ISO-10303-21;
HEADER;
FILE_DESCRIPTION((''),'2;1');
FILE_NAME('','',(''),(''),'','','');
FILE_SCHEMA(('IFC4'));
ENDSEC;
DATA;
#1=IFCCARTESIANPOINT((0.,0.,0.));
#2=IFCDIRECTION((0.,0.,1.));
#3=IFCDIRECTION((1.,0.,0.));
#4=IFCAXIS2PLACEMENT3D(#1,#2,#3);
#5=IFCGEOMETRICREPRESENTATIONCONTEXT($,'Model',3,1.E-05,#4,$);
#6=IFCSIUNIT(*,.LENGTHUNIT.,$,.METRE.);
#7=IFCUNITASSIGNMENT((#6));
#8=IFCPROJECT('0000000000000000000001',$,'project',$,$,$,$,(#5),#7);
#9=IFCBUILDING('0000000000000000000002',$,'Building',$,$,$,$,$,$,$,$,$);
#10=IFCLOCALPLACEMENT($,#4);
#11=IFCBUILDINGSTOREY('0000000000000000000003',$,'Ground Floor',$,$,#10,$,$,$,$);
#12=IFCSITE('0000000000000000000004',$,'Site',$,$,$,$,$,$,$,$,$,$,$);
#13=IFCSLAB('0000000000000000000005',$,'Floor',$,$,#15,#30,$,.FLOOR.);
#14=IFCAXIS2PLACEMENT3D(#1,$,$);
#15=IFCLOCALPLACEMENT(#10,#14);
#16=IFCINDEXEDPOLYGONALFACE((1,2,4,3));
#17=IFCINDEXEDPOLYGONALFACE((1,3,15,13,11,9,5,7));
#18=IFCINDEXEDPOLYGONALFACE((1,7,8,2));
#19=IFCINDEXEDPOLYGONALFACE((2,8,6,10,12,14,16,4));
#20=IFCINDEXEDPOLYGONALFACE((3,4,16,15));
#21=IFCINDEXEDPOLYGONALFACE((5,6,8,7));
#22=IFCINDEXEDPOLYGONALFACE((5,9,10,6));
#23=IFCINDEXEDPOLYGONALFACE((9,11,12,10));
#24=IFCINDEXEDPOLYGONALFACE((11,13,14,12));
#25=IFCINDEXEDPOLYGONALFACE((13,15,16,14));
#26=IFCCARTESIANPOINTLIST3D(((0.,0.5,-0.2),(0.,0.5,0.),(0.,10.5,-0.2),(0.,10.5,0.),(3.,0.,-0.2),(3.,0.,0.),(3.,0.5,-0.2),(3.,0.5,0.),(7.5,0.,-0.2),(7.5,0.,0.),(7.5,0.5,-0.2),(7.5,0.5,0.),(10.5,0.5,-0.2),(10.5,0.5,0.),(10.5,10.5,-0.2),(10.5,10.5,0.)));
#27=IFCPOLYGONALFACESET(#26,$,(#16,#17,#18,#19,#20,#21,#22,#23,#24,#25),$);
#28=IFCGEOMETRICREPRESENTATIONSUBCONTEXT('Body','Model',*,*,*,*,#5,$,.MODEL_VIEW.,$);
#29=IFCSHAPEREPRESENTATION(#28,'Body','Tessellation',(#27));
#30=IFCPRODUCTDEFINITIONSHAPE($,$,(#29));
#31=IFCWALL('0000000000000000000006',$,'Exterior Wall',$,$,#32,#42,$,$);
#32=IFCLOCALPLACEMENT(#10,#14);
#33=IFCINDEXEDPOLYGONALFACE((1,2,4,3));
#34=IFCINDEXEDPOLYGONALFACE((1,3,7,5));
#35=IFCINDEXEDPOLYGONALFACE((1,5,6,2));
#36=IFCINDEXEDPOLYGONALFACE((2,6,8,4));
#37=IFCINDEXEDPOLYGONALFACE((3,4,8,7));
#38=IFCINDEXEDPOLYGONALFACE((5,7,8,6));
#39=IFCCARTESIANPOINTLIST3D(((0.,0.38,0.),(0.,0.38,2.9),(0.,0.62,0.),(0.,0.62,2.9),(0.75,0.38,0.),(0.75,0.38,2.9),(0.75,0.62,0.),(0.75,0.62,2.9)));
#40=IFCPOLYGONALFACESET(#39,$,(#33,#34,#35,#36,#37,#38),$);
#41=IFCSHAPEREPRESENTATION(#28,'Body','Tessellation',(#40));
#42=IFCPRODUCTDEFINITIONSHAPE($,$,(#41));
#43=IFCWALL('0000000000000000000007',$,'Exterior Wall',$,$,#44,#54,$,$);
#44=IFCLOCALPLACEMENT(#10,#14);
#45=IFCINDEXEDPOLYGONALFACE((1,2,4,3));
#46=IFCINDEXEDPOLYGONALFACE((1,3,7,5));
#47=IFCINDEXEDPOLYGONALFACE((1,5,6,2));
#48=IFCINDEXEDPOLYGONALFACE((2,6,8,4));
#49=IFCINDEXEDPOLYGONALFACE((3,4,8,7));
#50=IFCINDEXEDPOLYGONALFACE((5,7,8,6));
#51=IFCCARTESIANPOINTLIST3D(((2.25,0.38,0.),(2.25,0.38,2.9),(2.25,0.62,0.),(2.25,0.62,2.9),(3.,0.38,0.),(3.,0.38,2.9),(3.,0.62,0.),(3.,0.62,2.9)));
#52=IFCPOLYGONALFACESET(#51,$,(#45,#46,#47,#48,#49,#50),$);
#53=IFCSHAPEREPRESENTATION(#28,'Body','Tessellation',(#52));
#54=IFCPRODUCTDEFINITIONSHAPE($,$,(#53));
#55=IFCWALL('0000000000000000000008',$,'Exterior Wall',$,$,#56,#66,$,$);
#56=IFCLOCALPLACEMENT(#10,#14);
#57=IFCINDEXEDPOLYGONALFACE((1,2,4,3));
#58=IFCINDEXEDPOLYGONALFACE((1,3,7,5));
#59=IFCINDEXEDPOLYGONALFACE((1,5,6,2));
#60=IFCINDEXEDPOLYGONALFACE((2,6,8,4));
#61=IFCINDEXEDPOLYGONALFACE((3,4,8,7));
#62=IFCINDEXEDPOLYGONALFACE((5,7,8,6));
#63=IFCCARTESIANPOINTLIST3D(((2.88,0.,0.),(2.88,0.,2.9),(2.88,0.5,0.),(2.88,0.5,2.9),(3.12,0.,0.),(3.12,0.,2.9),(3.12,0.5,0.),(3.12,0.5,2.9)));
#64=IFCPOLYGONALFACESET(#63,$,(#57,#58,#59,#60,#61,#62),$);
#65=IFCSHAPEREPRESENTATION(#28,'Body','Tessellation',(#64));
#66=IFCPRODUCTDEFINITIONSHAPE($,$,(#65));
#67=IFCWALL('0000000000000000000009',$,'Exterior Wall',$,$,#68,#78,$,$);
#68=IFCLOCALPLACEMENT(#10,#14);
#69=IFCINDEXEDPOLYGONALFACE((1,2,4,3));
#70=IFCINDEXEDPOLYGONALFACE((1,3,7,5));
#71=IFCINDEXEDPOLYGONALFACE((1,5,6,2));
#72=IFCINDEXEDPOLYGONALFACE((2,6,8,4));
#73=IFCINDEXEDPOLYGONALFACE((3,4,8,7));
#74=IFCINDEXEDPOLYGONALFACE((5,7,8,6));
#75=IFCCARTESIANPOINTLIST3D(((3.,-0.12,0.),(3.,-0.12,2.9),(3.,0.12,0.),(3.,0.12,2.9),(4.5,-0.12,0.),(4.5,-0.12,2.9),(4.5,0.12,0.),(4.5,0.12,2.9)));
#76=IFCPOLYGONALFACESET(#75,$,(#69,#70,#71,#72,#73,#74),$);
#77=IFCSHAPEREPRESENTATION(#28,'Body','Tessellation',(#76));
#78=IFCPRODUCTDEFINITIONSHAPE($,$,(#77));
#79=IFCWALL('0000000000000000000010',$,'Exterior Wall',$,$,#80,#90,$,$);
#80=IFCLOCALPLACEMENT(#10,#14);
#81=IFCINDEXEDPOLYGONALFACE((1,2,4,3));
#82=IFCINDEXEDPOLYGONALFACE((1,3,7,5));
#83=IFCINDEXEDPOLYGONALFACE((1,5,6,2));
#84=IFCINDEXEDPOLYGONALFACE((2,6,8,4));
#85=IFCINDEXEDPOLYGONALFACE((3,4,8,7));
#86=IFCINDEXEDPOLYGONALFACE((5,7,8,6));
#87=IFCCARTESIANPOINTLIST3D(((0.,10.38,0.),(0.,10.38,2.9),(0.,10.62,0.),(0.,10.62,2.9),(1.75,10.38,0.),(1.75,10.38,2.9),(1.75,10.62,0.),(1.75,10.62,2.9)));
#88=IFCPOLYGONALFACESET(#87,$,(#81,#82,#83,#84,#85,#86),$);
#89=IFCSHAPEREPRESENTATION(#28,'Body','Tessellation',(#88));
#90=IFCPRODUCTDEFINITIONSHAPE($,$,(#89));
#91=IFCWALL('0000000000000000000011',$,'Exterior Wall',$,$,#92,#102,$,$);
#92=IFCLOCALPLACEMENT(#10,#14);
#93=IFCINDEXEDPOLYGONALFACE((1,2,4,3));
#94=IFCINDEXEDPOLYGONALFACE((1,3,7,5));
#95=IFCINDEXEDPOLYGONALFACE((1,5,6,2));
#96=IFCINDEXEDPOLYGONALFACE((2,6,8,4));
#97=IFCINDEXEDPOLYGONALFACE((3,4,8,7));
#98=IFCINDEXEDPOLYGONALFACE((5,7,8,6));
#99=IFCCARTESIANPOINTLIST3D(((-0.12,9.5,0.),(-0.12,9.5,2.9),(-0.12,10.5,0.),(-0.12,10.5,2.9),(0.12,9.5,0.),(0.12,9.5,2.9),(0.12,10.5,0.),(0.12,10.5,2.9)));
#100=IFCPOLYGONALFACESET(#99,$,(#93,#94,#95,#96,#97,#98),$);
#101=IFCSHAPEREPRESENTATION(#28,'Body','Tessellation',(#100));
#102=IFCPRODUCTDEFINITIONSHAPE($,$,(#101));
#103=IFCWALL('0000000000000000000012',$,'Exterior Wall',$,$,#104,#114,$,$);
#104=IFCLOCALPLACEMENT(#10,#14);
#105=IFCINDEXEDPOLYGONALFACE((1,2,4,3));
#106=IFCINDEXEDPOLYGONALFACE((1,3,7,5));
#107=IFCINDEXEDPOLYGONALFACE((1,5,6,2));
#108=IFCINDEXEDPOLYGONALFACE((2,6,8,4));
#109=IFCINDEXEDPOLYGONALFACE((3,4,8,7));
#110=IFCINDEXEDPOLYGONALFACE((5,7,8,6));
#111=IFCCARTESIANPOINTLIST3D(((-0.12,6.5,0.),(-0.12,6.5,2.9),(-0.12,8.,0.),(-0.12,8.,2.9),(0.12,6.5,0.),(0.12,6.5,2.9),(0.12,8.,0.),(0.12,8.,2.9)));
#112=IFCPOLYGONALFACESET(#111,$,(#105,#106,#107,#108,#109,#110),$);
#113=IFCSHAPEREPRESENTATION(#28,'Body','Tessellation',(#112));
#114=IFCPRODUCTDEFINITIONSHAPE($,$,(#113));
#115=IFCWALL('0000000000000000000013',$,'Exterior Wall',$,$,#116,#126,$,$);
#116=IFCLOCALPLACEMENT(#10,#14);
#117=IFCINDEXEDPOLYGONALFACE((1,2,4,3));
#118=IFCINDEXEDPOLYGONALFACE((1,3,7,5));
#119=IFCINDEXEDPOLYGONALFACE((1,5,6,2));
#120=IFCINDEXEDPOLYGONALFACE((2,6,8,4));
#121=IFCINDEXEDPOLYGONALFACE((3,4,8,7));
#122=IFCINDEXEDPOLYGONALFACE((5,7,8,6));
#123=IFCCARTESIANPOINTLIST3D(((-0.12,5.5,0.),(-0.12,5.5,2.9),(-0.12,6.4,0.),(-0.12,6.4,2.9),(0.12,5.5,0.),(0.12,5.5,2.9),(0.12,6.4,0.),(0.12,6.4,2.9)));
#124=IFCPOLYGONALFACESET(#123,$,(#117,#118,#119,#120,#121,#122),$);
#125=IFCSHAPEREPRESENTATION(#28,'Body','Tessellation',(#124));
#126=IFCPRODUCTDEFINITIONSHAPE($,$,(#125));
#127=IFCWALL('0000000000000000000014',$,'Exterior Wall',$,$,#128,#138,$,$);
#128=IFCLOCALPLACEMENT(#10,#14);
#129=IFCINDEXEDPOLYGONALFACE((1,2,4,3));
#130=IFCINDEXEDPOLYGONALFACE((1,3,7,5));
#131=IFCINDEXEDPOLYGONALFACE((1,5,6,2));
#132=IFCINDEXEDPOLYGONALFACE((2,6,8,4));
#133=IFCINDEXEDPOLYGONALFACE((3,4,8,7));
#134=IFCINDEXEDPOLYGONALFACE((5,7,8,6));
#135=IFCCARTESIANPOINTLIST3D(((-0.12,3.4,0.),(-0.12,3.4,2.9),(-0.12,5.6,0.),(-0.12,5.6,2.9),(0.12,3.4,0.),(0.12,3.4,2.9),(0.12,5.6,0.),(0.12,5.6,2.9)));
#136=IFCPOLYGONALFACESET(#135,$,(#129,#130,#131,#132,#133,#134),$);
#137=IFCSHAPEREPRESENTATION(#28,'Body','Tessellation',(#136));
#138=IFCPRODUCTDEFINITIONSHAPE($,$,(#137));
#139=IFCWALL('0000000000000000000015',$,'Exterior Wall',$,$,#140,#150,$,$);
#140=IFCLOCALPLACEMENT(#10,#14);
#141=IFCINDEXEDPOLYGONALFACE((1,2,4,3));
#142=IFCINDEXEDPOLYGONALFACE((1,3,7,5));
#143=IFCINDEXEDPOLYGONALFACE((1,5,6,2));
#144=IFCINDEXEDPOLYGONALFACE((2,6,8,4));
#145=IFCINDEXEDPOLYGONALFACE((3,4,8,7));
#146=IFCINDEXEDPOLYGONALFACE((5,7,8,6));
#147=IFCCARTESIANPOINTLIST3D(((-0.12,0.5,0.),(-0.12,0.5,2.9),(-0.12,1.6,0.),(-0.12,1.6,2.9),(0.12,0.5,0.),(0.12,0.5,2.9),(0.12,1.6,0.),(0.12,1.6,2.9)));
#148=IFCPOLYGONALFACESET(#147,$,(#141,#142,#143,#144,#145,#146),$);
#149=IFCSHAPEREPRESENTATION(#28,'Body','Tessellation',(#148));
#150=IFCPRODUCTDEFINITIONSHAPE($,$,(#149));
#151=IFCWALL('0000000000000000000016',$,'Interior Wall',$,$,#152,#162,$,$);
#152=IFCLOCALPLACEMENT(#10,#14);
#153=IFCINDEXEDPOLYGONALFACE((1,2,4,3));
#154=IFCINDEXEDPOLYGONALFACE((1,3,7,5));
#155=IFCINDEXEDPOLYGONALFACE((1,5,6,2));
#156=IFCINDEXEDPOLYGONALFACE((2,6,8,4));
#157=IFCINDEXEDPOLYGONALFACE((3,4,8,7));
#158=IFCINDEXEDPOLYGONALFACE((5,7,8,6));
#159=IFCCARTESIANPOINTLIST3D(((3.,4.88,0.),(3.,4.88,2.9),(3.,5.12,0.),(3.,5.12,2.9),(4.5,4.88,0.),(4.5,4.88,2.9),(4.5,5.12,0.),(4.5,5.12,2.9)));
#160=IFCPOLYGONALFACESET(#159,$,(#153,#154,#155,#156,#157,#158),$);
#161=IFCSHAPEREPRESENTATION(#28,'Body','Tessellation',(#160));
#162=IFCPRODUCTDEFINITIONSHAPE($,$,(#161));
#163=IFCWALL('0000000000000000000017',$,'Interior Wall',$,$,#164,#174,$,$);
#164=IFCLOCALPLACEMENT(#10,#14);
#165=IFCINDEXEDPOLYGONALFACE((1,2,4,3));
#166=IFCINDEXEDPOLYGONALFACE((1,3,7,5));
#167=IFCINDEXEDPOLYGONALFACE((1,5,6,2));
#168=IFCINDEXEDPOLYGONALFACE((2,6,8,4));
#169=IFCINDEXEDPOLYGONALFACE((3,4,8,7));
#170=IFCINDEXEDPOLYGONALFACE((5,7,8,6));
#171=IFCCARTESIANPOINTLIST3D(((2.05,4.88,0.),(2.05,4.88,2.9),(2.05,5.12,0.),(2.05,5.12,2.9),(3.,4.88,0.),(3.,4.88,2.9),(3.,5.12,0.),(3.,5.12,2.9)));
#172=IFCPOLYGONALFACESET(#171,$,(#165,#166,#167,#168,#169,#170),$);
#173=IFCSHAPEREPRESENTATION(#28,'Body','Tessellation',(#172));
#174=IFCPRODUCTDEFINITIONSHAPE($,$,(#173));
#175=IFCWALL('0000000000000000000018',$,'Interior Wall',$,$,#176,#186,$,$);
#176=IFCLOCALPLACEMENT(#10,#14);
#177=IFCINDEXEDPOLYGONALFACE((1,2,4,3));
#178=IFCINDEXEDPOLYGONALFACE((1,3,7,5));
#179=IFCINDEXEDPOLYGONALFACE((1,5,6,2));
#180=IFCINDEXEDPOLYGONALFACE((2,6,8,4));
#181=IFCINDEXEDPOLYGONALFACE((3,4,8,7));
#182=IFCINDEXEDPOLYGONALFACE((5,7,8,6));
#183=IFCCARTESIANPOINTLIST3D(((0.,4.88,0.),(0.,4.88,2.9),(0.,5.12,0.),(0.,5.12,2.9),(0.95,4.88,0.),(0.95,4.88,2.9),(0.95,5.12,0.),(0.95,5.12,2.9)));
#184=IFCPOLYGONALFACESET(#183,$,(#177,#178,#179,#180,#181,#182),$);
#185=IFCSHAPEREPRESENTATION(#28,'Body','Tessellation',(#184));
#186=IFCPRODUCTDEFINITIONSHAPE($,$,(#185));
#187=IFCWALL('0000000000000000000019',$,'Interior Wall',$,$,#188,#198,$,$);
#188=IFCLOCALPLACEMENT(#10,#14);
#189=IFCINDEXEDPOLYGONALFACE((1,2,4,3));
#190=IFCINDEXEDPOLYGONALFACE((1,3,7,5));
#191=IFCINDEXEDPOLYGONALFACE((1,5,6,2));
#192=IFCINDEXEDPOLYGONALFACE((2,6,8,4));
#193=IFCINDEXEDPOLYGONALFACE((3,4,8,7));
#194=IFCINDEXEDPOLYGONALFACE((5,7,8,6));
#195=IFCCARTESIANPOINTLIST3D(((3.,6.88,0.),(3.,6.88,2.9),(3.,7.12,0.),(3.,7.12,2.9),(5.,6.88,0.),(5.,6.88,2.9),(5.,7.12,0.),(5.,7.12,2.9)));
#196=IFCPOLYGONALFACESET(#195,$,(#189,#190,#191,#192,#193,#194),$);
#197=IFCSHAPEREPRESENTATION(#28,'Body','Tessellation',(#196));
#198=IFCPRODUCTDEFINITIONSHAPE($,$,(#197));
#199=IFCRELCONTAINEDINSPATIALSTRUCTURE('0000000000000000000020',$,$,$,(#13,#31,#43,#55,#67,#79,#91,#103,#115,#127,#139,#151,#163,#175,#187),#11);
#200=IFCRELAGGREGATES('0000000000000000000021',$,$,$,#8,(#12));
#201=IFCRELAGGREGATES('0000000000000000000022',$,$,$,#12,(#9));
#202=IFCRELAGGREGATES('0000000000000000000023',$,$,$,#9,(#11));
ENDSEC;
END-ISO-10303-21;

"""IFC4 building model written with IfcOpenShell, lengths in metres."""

from ifc_helpers import new_model, si_unit, frame, origin_with_axes, place, context, subcontext, project, spatial, indexed_curve, outline, extrude, element, save


model = new_model("IFC4")

# Units and contexts
model_context = context("Model", 3, precision=1e-05, world=origin_with_axes())
body_context = subcontext(model_context, "Body", "Model", "MODEL_VIEW")
ifc_project = project(units=[si_unit("LENGTHUNIT", "METRE")], contexts=[model_context])

# Site, building, storey
site = spatial("IfcSite", under=ifc_project, Name="Site")
building = spatial("IfcBuilding", under=site, Name="Building")
storey_placement = place(None, origin_with_axes())
storey = spatial("IfcBuildingStorey", under=building, at=storey_placement, Name="Ground Floor")

# Slab
slab_placement = place(storey_placement, frame((0.0, 0.0, -0.2), z_axis=(0.0, 0.0, 1.0), x_axis=(1.0, 0.0, 0.0)))
element("IfcSlab", 1, at=slab_placement, inside=storey, Name="Floor", PredefinedType="FLOOR", context=body_context, shape_type="SweptSolid", body=[
    extrude(outline(indexed_curve([(0.0, 0.5), (3.0, 0.5), (3.0, 0.0), (7.5, 0.0), (7.5, 0.5), (10.5, 0.5), (10.5, 10.5), (0.0, 10.5)])), None, (0.0, 0.0, 1.0), 0.2),
])

# Walls
for number, where, z_axis, x_axis, name in (
    (2, (0.0, 0.5, 0.0), (0.0, 0.0, 1.0), (1.0, 0.0, 0.0), "Exterior Wall"),
    (3, (2.25, 0.5, 0.0), (0.0, 0.0, 1.0), (1.0, 0.0, 0.0), "Exterior Wall"),
):
    element("IfcWall", number, at=place(storey_placement, frame(where, z_axis=z_axis, x_axis=x_axis)), inside=storey, Name=name, context=body_context, shape_type="SweptSolid", body=[
        extrude(outline(indexed_curve([(0.0, 0.0), (0.0, 0.24), (0.75, 0.24), (0.75, 0.0), (0.0, 0.0)], self_intersect=False)), frame((0.0, -0.12, 0.0), z_axis=(0.0, 0.0, 1.0), x_axis=(1.0, 0.0, 0.0)), (0.0, 0.0, 1.0), 2.9),
    ])
wall_1_placement = place(storey_placement, frame((3.0, 0.5, 0.0), z_axis=(0.0, 0.0, 1.0), x_axis=(0.0, -1.0, 0.0)))
element("IfcWall", 4, at=wall_1_placement, inside=storey, Name="Exterior Wall", context=body_context, shape_type="SweptSolid", body=[
    extrude(outline(indexed_curve([(0.0, 0.0), (0.0, 0.24), (0.5, 0.24), (0.5, 0.0), (0.0, 0.0)], self_intersect=False)), frame((0.0, -0.12, 0.0), z_axis=(0.0, 0.0, 1.0), x_axis=(1.0, 0.0, 0.0)), (0.0, 0.0, 1.0), 2.9),
])
wall_2_placement = place(storey_placement, frame((3.0, 0.0, 0.0), z_axis=(0.0, 0.0, 1.0), x_axis=(1.0, 0.0, 0.0)))
element("IfcWall", 5, at=wall_2_placement, inside=storey, Name="Exterior Wall", context=body_context, shape_type="SweptSolid", body=[
    extrude(outline(indexed_curve([(0.0, 0.0), (0.0, 0.24), (1.5, 0.24), (1.5, 0.0), (0.0, 0.0)], self_intersect=False)), frame((0.0, -0.12, 0.0), z_axis=(0.0, 0.0, 1.0), x_axis=(1.0, 0.0, 0.0)), (0.0, 0.0, 1.0), 2.9),
])
wall_3_placement = place(storey_placement, frame((1.75, 10.5, 0.0), z_axis=(0.0, 0.0, 1.0), x_axis=(-1.0, 0.0, 0.0)))
element("IfcWall", 6, at=wall_3_placement, inside=storey, Name="Exterior Wall", context=body_context, shape_type="SweptSolid", body=[
    extrude(outline(indexed_curve([(0.0, 0.0), (0.0, 0.24), (1.75, 0.24), (1.75, 0.0), (0.0, 0.0)], self_intersect=False)), frame((0.0, -0.12, 0.0), z_axis=(0.0, 0.0, 1.0), x_axis=(1.0, 0.0, 0.0)), (0.0, 0.0, 1.0), 2.9),
])
wall_4_placement = place(storey_placement, frame((0.0, 10.5, 0.0), z_axis=(0.0, 0.0, 1.0), x_axis=(0.0, -1.0, 0.0)))
element("IfcWall", 7, at=wall_4_placement, inside=storey, Name="Exterior Wall", context=body_context, shape_type="SweptSolid", body=[
    extrude(outline(indexed_curve([(0.0, 0.0), (0.0, 0.24), (1.0, 0.24), (1.0, 0.0), (0.0, 0.0)], self_intersect=False)), frame((0.0, -0.12, 0.0), z_axis=(0.0, 0.0, 1.0), x_axis=(1.0, 0.0, 0.0)), (0.0, 0.0, 1.0), 2.9),
])
wall_5_placement = place(storey_placement, frame((0.0, 8.0, 0.0), z_axis=(0.0, 0.0, 1.0), x_axis=(0.0, -1.0, 0.0)))
element("IfcWall", 8, at=wall_5_placement, inside=storey, Name="Exterior Wall", context=body_context, shape_type="SweptSolid", body=[
    extrude(outline(indexed_curve([(0.0, 0.0), (0.0, 0.24), (1.5, 0.24), (1.5, 0.0), (0.0, 0.0)], self_intersect=False)), frame((0.0, -0.12, 0.0), z_axis=(0.0, 0.0, 1.0), x_axis=(1.0, 0.0, 0.0)), (0.0, 0.0, 1.0), 2.9),
])
wall_6_placement = place(storey_placement, frame((0.0, 5.5, 0.0), z_axis=(0.0, 0.0, 1.0), x_axis=(0.0, 1.0, 0.0)))
element("IfcWall", 9, at=wall_6_placement, inside=storey, Name="Exterior Wall", context=body_context, shape_type="SweptSolid", body=[
    extrude(outline(indexed_curve([(0.0, 0.0), (0.0, 0.24), (0.9, 0.24), (0.9, 0.0), (0.0, 0.0)], self_intersect=False)), frame((0.0, -0.12, 0.0), z_axis=(0.0, 0.0, 1.0), x_axis=(1.0, 0.0, 0.0)), (0.0, 0.0, 1.0), 2.9),
])
wall_7_placement = place(storey_placement, frame((0.0, 5.6, 0.0), z_axis=(0.0, 0.0, 1.0), x_axis=(0.0, -1.0, 0.0)))
element("IfcWall", 10, at=wall_7_placement, inside=storey, Name="Exterior Wall", context=body_context, shape_type="SweptSolid", body=[
    extrude(outline(indexed_curve([(0.0, 0.0), (0.0, 0.24), (2.2, 0.24), (2.2, 0.0), (0.0, 0.0)], self_intersect=False)), frame((0.0, -0.12, 0.0), z_axis=(0.0, 0.0, 1.0), x_axis=(1.0, 0.0, 0.0)), (0.0, 0.0, 1.0), 2.9),
])
wall_8_placement = place(storey_placement, frame((0.0, 1.6, 0.0), z_axis=(0.0, 0.0, 1.0), x_axis=(0.0, -1.0, 0.0)))
element("IfcWall", 11, at=wall_8_placement, inside=storey, Name="Exterior Wall", context=body_context, shape_type="SweptSolid", body=[
    extrude(outline(indexed_curve([(0.0, 0.0), (0.0, 0.24), (1.1, 0.24), (1.1, 0.0), (0.0, 0.0)], self_intersect=False)), frame((0.0, -0.12, 0.0), z_axis=(0.0, 0.0, 1.0), x_axis=(1.0, 0.0, 0.0)), (0.0, 0.0, 1.0), 2.9),
])
wall_9_placement = place(storey_placement, frame((4.5, 5.0, 0.0), z_axis=(0.0, 0.0, 1.0), x_axis=(-1.0, 0.0, 0.0)))
element("IfcWall", 12, at=wall_9_placement, inside=storey, Name="Interior Wall", context=body_context, shape_type="SweptSolid", body=[
    extrude(outline(indexed_curve([(0.0, 0.0), (0.0, 0.24), (1.5, 0.24), (1.5, 0.0), (0.0, 0.0)], self_intersect=False)), frame((0.0, -0.12, 0.0), z_axis=(0.0, 0.0, 1.0), x_axis=(1.0, 0.0, 0.0)), (0.0, 0.0, 1.0), 2.9),
])
for number, where, z_axis, x_axis, name in (
    (13, (3.0, 5.0, 0.0), (0.0, 0.0, 1.0), (-1.0, 0.0, 0.0), "Interior Wall"),
    (14, (0.95, 5.0, 0.0), (0.0, 0.0, 1.0), (-1.0, 0.0, 0.0), "Interior Wall"),
):
    element("IfcWall", number, at=place(storey_placement, frame(where, z_axis=z_axis, x_axis=x_axis)), inside=storey, Name=name, context=body_context, shape_type="SweptSolid", body=[
        extrude(outline(indexed_curve([(0.0, 0.0), (0.0, 0.24), (0.95, 0.24), (0.95, 0.0), (0.0, 0.0)], self_intersect=False)), frame((0.0, -0.12, 0.0), z_axis=(0.0, 0.0, 1.0), x_axis=(1.0, 0.0, 0.0)), (0.0, 0.0, 1.0), 2.9),
    ])
wall_10_placement = place(storey_placement, frame((5.0, 7.0, 0.0), z_axis=(0.0, 0.0, 1.0), x_axis=(-1.0, 0.0, 0.0)))
element("IfcWall", 15, at=wall_10_placement, inside=storey, Name="Interior Wall", context=body_context, shape_type="SweptSolid", body=[
    extrude(outline(indexed_curve([(0.0, 0.0), (0.0, 0.24), (2.0, 0.24), (2.0, 0.0), (0.0, 0.0)], self_intersect=False)), frame((0.0, -0.12, 0.0), z_axis=(0.0, 0.0, 1.0), x_axis=(1.0, 0.0, 0.0)), (0.0, 0.0, 1.0), 2.9),
])

save(model, "model.ifc")
